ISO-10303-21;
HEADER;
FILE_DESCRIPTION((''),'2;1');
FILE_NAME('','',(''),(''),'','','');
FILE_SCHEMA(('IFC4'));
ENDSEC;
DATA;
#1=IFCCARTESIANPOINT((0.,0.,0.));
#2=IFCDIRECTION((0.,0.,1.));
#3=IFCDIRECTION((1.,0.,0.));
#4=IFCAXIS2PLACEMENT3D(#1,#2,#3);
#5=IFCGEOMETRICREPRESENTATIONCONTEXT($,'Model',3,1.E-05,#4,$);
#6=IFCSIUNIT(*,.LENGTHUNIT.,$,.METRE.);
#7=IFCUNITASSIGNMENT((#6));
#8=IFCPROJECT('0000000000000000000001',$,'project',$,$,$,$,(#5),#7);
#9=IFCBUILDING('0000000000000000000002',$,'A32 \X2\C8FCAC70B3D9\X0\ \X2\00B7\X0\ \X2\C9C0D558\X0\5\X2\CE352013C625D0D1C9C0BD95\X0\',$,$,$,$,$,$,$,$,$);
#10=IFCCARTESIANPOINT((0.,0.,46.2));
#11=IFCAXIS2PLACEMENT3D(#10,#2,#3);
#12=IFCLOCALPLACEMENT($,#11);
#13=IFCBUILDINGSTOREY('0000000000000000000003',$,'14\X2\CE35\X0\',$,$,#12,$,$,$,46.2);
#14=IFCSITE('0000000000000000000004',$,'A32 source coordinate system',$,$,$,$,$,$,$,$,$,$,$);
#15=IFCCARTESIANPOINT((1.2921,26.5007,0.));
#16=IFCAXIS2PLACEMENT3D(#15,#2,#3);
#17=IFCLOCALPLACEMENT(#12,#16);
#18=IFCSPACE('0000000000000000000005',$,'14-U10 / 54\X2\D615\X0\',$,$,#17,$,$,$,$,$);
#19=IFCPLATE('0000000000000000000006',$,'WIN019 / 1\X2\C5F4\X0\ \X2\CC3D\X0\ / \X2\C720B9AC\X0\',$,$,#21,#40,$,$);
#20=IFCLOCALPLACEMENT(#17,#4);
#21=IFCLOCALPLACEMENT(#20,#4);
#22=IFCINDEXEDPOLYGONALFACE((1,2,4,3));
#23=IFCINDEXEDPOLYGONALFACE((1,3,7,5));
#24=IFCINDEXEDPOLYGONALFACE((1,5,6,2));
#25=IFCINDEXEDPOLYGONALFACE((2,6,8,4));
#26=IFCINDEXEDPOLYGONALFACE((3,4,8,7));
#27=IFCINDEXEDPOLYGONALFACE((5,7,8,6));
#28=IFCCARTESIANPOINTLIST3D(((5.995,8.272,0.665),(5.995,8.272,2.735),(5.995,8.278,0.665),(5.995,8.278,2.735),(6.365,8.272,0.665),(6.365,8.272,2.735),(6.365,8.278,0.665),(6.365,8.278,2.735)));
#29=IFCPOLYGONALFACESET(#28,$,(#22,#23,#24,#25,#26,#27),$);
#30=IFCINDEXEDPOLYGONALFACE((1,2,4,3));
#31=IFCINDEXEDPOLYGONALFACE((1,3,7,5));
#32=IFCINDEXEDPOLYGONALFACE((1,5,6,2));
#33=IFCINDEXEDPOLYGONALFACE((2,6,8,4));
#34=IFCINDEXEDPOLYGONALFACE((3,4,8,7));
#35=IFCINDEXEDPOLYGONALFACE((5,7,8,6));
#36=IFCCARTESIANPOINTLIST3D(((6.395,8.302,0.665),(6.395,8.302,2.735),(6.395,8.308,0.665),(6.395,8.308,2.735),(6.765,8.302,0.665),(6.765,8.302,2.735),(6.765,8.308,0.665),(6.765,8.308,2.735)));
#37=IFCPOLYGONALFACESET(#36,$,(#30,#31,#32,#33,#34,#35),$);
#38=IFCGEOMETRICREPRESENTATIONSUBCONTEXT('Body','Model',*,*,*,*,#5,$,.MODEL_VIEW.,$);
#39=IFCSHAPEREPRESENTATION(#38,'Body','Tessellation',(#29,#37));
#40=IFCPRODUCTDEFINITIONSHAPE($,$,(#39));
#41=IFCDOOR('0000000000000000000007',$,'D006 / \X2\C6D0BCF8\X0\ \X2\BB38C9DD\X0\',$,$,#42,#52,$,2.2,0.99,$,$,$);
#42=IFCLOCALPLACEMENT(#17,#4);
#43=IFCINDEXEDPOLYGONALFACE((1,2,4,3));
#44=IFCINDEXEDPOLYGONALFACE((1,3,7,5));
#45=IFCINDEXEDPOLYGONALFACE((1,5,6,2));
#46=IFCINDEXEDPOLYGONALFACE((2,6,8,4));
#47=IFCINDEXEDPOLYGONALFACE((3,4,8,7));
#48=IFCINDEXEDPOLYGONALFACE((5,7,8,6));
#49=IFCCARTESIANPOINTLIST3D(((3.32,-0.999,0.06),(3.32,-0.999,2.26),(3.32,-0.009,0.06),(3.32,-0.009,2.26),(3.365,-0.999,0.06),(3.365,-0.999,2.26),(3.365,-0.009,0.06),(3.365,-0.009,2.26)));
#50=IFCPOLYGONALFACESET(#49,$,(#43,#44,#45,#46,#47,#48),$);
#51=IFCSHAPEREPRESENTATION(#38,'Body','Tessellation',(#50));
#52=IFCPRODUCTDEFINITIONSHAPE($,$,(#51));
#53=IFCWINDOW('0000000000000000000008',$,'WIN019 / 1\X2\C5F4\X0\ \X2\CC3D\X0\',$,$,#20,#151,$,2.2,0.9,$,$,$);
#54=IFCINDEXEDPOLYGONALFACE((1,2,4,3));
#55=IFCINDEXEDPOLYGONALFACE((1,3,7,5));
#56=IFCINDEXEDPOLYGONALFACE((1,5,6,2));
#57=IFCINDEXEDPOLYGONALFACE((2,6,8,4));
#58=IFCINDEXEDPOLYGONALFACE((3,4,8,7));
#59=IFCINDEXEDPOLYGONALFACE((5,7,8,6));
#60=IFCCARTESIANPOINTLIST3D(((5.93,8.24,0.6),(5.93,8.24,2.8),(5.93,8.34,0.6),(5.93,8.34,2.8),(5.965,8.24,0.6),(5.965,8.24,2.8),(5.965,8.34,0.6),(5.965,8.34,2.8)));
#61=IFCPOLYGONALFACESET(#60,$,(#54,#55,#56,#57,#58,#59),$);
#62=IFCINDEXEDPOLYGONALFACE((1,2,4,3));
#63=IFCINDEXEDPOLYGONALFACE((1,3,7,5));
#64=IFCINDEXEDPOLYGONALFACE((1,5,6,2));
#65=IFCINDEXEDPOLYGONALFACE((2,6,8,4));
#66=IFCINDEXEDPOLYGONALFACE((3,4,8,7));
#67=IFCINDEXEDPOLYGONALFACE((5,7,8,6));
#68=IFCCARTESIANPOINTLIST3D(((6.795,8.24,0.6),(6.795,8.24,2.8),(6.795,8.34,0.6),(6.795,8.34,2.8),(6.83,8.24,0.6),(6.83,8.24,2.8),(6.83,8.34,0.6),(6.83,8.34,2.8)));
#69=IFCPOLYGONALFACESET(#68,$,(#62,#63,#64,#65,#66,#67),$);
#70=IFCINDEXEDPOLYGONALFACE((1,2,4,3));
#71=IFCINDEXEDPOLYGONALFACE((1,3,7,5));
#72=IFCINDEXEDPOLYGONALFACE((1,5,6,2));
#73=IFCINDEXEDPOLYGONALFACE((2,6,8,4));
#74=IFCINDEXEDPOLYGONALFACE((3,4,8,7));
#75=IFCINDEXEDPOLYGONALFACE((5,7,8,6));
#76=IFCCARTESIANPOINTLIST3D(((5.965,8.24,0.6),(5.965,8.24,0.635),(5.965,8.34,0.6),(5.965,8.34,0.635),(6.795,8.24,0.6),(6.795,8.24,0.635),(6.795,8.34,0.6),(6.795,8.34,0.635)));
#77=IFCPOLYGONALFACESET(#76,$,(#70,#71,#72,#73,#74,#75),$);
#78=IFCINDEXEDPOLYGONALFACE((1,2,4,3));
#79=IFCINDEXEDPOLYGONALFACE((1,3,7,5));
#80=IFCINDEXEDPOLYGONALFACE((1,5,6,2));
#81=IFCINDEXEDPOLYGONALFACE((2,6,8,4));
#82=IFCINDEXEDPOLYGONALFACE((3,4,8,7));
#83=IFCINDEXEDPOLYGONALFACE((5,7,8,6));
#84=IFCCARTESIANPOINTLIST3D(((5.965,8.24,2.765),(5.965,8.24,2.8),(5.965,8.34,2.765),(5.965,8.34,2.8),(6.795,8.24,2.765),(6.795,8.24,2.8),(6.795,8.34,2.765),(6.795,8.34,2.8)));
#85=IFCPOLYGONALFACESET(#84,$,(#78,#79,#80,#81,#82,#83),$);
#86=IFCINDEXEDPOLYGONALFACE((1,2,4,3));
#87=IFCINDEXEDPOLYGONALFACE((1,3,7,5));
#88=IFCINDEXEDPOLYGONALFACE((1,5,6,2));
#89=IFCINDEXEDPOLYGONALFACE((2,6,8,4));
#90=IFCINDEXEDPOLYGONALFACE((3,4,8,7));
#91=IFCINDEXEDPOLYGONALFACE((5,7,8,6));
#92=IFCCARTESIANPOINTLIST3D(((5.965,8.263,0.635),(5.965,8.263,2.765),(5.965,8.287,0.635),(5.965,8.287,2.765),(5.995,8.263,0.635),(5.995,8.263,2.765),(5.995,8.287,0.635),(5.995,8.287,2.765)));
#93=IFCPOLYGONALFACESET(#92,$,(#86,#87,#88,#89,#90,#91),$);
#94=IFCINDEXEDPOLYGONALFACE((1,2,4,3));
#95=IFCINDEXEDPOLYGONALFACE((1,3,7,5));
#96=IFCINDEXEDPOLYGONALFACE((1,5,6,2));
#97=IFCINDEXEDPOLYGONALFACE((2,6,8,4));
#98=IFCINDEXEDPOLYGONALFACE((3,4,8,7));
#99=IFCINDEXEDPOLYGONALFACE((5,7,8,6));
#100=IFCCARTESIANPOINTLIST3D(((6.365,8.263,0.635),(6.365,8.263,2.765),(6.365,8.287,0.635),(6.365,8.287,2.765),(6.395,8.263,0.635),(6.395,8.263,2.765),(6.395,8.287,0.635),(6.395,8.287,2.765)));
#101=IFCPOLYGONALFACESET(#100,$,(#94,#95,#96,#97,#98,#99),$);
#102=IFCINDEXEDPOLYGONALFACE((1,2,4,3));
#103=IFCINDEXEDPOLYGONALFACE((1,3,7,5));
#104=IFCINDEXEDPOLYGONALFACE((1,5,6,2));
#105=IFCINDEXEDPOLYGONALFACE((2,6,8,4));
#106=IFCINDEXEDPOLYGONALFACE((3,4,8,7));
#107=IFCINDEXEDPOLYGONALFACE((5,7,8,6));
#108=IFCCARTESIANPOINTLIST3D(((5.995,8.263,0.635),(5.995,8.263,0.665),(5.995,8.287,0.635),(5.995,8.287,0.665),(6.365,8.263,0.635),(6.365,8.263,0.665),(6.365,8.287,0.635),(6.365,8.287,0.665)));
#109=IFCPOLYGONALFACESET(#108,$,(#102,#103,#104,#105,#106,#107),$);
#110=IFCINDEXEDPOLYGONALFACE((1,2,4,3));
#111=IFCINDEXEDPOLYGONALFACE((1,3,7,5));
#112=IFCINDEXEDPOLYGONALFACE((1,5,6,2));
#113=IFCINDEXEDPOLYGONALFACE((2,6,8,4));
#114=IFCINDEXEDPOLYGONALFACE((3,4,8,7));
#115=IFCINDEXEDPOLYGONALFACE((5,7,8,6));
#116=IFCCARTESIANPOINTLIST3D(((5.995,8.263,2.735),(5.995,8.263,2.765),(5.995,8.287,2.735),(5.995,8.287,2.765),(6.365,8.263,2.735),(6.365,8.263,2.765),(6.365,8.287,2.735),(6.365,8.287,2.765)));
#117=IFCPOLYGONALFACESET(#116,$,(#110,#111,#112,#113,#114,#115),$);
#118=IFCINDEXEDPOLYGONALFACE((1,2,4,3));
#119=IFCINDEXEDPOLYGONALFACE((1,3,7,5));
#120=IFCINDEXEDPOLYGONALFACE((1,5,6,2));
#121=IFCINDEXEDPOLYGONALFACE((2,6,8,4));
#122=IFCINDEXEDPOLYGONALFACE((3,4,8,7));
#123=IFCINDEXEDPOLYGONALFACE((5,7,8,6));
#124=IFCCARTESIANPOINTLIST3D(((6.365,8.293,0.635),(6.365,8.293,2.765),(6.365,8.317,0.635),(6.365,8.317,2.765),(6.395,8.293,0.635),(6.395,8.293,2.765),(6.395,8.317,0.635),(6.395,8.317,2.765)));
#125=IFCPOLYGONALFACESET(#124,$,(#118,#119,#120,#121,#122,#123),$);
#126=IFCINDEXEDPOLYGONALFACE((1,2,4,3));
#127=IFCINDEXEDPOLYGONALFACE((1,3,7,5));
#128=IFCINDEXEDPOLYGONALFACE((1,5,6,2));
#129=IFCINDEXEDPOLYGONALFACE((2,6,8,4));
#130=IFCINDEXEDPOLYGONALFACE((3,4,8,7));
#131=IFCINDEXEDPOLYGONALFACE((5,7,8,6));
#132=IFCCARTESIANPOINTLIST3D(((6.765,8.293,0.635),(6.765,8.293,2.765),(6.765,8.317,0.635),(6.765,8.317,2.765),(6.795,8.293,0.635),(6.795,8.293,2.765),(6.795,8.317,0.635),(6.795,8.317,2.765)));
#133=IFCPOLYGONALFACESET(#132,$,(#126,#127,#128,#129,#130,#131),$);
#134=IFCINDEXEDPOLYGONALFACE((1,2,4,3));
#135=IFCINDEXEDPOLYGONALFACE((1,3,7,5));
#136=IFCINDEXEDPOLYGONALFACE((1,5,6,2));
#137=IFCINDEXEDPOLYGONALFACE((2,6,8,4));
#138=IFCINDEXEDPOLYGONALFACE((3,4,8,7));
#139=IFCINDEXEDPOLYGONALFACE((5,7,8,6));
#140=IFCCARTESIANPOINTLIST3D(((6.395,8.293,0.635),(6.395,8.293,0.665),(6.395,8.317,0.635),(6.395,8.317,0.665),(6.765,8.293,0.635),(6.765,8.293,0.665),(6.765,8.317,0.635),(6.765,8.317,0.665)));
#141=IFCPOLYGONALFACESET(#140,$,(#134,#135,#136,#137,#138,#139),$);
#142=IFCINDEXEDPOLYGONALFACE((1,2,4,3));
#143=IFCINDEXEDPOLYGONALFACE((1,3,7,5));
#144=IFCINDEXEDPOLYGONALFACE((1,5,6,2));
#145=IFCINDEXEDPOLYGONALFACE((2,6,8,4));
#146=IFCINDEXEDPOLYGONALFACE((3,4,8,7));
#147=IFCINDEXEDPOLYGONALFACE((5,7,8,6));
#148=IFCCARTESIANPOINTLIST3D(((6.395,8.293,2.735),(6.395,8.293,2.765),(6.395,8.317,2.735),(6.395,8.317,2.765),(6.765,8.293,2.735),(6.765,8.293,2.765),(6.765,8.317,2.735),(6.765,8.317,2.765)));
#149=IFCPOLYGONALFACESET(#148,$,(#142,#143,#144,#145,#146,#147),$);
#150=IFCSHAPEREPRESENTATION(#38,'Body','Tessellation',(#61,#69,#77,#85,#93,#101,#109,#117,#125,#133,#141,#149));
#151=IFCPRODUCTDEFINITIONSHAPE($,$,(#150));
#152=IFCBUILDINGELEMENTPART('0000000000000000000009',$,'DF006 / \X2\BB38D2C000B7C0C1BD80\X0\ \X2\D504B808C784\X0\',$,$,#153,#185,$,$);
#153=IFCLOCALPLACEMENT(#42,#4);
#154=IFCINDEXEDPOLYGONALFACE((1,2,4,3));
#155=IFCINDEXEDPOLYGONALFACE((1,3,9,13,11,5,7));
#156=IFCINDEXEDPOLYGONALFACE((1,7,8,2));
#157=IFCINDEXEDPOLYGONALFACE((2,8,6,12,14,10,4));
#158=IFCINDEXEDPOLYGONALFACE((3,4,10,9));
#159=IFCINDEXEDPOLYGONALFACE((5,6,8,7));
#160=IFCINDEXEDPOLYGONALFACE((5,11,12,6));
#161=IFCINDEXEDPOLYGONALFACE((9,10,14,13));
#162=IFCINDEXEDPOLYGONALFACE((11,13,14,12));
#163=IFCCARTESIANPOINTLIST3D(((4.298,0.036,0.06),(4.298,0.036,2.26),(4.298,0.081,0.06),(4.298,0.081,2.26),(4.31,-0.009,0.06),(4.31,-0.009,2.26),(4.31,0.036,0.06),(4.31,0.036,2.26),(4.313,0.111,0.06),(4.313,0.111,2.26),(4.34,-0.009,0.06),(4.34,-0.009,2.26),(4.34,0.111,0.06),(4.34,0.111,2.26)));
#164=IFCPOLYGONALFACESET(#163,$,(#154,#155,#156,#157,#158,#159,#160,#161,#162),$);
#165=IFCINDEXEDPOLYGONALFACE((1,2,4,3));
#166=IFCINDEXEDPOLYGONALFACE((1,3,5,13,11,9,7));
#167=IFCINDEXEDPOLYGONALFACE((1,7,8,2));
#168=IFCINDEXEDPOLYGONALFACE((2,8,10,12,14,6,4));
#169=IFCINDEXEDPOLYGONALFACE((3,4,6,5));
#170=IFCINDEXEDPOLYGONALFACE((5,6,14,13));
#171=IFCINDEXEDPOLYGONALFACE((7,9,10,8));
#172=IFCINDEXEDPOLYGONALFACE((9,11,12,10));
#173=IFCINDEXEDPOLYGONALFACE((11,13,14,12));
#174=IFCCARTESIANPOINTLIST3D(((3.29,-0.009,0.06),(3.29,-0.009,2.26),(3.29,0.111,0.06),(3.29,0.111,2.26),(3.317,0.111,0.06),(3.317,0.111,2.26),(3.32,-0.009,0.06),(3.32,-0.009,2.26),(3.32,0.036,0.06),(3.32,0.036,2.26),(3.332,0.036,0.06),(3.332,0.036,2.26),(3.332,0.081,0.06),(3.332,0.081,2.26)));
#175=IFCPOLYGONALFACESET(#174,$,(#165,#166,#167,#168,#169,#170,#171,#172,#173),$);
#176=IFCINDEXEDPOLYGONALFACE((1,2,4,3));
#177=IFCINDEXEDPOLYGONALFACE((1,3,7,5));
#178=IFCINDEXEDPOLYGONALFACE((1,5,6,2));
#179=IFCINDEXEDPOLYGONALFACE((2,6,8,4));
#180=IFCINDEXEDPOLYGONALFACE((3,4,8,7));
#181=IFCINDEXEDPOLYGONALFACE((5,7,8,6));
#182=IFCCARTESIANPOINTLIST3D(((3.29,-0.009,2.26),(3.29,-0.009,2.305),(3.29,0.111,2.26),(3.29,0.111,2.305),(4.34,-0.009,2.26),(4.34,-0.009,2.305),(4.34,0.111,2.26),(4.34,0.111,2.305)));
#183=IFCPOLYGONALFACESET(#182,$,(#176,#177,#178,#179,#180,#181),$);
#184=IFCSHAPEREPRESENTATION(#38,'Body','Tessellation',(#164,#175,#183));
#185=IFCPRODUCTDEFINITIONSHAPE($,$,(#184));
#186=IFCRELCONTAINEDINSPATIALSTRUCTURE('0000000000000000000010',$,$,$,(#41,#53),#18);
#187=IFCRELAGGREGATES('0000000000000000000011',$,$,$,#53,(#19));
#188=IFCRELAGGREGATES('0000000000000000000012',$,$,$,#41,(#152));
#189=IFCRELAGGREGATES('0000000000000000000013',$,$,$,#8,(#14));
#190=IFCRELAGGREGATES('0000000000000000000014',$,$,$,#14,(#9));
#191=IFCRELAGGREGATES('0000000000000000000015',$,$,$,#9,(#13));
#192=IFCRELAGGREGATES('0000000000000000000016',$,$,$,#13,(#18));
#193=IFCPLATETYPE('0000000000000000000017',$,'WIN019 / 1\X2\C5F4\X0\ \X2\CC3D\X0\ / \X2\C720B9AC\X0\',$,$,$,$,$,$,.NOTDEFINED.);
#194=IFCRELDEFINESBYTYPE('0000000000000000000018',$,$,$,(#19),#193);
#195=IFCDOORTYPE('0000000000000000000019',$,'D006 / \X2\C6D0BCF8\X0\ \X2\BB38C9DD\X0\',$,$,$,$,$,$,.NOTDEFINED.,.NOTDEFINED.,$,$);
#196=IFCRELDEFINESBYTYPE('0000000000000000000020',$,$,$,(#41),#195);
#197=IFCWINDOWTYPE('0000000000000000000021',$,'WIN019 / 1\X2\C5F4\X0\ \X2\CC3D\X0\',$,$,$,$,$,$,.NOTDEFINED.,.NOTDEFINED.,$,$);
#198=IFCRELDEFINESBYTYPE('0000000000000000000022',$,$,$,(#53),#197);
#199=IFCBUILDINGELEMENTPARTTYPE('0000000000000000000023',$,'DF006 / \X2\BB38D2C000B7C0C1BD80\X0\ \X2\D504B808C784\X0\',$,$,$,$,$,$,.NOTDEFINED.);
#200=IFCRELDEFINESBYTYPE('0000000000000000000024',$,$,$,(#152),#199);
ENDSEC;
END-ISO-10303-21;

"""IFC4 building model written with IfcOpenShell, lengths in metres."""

from ifc_helpers import new_model, si_unit, frame, origin, origin_with_axes, place, context, subcontext, project, spatial, polyline, outline, extrude, source, transform, mapped, type_object, type_shapes, element, aggregate, save


model = new_model("IFC4")

# Units and contexts
model_context = context("Model", 3, precision=1e-05, world=origin_with_axes())
body_context = subcontext(model_context, "Body", "Model", "MODEL_VIEW")
ifc_project = project(units=[si_unit("LENGTHUNIT", "METRE")], contexts=[model_context])

# Plate
storey_placement = place(None, frame((0.0, 0.0, 46.2), z_axis=(0.0, 0.0, 1.0), x_axis=(1.0, 0.0, 0.0)))
space_placement = place(storey_placement, frame((1.2921, 26.5007, 0.0), z_axis=(0.0, 0.0, 1.0), x_axis=(1.0, 0.0, 0.0)))
plate_type_1 = type_object("IfcPlateType", Name="WIN019 / 1열 창 / 유리", PredefinedType="NOTDEFINED")
shared_shape_1 = source(origin(), body_context, "Body", "SweptSolid", [
    extrude(outline(polyline([(5.995, 8.272), (5.995, 8.278), (6.365, 8.278), (6.365, 8.272), (5.995, 8.272)])), frame((0.0, 0.0, 0.665)), (0.0, 0.0, 1.0), 2.07),
    extrude(outline(polyline([(6.395, 8.302), (6.395, 8.308), (6.765, 8.308), (6.765, 8.302), (6.395, 8.302)])), frame((0.0, 0.0, 0.665)), (0.0, 0.0, 1.0), 2.07),
])
type_shapes(plate_type_1, [shared_shape_1])
window_1_placement = place(space_placement, origin_with_axes())
plate_1_placement = place(window_1_placement, origin_with_axes())
plate_1 = element("IfcPlate", 1, at=plate_1_placement, type_object=plate_type_1, Name="WIN019 / 1열 창 / 유리", context=body_context, shape_type="MappedRepresentation", body=[
    mapped(shared_shape_1, transform((0.0, 0.0, 0.0), scale=1.0)),
])

# Site, building, storey, space
site = spatial("IfcSite", under=ifc_project, Name="A32 source coordinate system")
building = spatial("IfcBuilding", under=site, Name="A32 주거동 · 지하5층–옥탑지붕")
storey = spatial("IfcBuildingStorey", under=building, at=storey_placement, Name="14층", Elevation=46.2)
space = spatial("IfcSpace", under=storey, at=space_placement, Name="14-U10 / 54형")

# Door
door_type_1 = type_object("IfcDoorType", Name="D006 / 원본 문짝", OperationType="NOTDEFINED", PredefinedType="NOTDEFINED")
shared_shape_2 = source(origin(), body_context, "Body", "SweptSolid", [
    extrude(outline(polyline([(3.365, -0.999), (3.32, -0.999), (3.32, -0.009), (3.365, -0.009), (3.365, -0.999)])), frame((0.0, 0.0, 0.06)), (0.0, 0.0, 1.0), 2.2),
])
type_shapes(door_type_1, [shared_shape_2])
door_1_placement = place(space_placement, origin_with_axes())
door_1 = element("IfcDoor", 2, at=door_1_placement, inside=space, type_object=door_type_1, Name="D006 / 원본 문짝", OverallHeight=2.2, OverallWidth=0.99, context=body_context, shape_type="MappedRepresentation", body=[
    mapped(shared_shape_2, transform((0.0, 0.0, 0.0), scale=1.0)),
])

# Window
window_type_1 = type_object("IfcWindowType", Name="WIN019 / 1열 창", PartitioningType="NOTDEFINED", PredefinedType="NOTDEFINED")
shared_shape_3 = source(origin(), body_context, "Body", "SweptSolid", [
    extrude(outline(polyline([(5.93, 8.24), (5.93, 8.34), (5.965, 8.34), (5.965, 8.24), (5.93, 8.24)])), frame((0.0, 0.0, 0.6)), (0.0, 0.0, 1.0), 2.2),
    extrude(outline(polyline([(6.795, 8.24), (6.795, 8.34), (6.83, 8.34), (6.83, 8.24), (6.795, 8.24)])), frame((0.0, 0.0, 0.6)), (0.0, 0.0, 1.0), 2.2),
    extrude(outline(polyline([(5.965, 8.24), (5.965, 8.34), (6.795, 8.34), (6.795, 8.24), (5.965, 8.24)])), frame((0.0, 0.0, 0.6)), (0.0, 0.0, 1.0), 0.035),
    extrude(outline(polyline([(5.965, 8.24), (5.965, 8.34), (6.795, 8.34), (6.795, 8.24), (5.965, 8.24)])), frame((0.0, 0.0, 2.765)), (0.0, 0.0, 1.0), 0.035),
    extrude(outline(polyline([(5.965, 8.263), (5.965, 8.287), (5.995, 8.287), (5.995, 8.263), (5.965, 8.263)])), frame((0.0, 0.0, 0.635)), (0.0, 0.0, 1.0), 2.13),
    extrude(outline(polyline([(6.365, 8.263), (6.365, 8.287), (6.395, 8.287), (6.395, 8.263), (6.365, 8.263)])), frame((0.0, 0.0, 0.635)), (0.0, 0.0, 1.0), 2.13),
    extrude(outline(polyline([(5.995, 8.263), (5.995, 8.287), (6.365, 8.287), (6.365, 8.263), (5.995, 8.263)])), frame((0.0, 0.0, 0.635)), (0.0, 0.0, 1.0), 0.03),
    extrude(outline(polyline([(5.995, 8.263), (5.995, 8.287), (6.365, 8.287), (6.365, 8.263), (5.995, 8.263)])), frame((0.0, 0.0, 2.735)), (0.0, 0.0, 1.0), 0.03),
    extrude(outline(polyline([(6.365, 8.293), (6.365, 8.317), (6.395, 8.317), (6.395, 8.293), (6.365, 8.293)])), frame((0.0, 0.0, 0.635)), (0.0, 0.0, 1.0), 2.13),
    extrude(outline(polyline([(6.765, 8.293), (6.765, 8.317), (6.795, 8.317), (6.795, 8.293), (6.765, 8.293)])), frame((0.0, 0.0, 0.635)), (0.0, 0.0, 1.0), 2.13),
    extrude(outline(polyline([(6.395, 8.293), (6.395, 8.317), (6.765, 8.317), (6.765, 8.293), (6.395, 8.293)])), frame((0.0, 0.0, 0.635)), (0.0, 0.0, 1.0), 0.03),
    extrude(outline(polyline([(6.395, 8.293), (6.395, 8.317), (6.765, 8.317), (6.765, 8.293), (6.395, 8.293)])), frame((0.0, 0.0, 2.735)), (0.0, 0.0, 1.0), 0.03),
])
type_shapes(window_type_1, [shared_shape_3])
window_1 = element("IfcWindow", 3, at=window_1_placement, inside=space, type_object=window_type_1, Name="WIN019 / 1열 창", OverallHeight=2.2, OverallWidth=0.9, context=body_context, shape_type="MappedRepresentation", body=[
    mapped(shared_shape_3, transform((0.0, 0.0, 0.0), scale=1.0)),
])
aggregate(window_1, [plate_1])

# Building element part
building_element_part_type_1 = type_object("IfcBuildingElementPartType", Name="DF006 / 문틀·상부 프레임", PredefinedType="NOTDEFINED")
shared_shape_4 = source(origin(), body_context, "Body", "SweptSolid", [
    extrude(outline(polyline([(4.31, -0.009), (4.31, 0.036), (4.298, 0.036), (4.298, 0.081), (4.313, 0.111), (4.34, 0.111), (4.34, -0.009), (4.31, -0.009)])), frame((0.0, 0.0, 0.06)), (0.0, 0.0, 1.0), 2.2),
    extrude(outline(polyline([(3.29, 0.111), (3.317, 0.111), (3.332, 0.081), (3.332, 0.036), (3.32, 0.036), (3.32, -0.009), (3.29, -0.009), (3.29, 0.111)])), frame((0.0, 0.0, 0.06)), (0.0, 0.0, 1.0), 2.2),
    extrude(outline(polyline([(3.29, -0.009), (3.29, 0.111), (4.34, 0.111), (4.34, -0.009), (3.29, -0.009)])), frame((0.0, 0.0, 2.26)), (0.0, 0.0, 1.0), 0.045),
])
type_shapes(building_element_part_type_1, [shared_shape_4])
building_element_part_1_placement = place(door_1_placement, origin_with_axes())
building_element_part_1 = element("IfcBuildingElementPart", 4, at=building_element_part_1_placement, type_object=building_element_part_type_1, Name="DF006 / 문틀·상부 프레임", context=body_context, shape_type="MappedRepresentation", body=[
    mapped(shared_shape_4, transform((0.0, 0.0, 0.0), scale=1.0)),
])
aggregate(door_1, [building_element_part_1])

save(model, "model.ifc")
